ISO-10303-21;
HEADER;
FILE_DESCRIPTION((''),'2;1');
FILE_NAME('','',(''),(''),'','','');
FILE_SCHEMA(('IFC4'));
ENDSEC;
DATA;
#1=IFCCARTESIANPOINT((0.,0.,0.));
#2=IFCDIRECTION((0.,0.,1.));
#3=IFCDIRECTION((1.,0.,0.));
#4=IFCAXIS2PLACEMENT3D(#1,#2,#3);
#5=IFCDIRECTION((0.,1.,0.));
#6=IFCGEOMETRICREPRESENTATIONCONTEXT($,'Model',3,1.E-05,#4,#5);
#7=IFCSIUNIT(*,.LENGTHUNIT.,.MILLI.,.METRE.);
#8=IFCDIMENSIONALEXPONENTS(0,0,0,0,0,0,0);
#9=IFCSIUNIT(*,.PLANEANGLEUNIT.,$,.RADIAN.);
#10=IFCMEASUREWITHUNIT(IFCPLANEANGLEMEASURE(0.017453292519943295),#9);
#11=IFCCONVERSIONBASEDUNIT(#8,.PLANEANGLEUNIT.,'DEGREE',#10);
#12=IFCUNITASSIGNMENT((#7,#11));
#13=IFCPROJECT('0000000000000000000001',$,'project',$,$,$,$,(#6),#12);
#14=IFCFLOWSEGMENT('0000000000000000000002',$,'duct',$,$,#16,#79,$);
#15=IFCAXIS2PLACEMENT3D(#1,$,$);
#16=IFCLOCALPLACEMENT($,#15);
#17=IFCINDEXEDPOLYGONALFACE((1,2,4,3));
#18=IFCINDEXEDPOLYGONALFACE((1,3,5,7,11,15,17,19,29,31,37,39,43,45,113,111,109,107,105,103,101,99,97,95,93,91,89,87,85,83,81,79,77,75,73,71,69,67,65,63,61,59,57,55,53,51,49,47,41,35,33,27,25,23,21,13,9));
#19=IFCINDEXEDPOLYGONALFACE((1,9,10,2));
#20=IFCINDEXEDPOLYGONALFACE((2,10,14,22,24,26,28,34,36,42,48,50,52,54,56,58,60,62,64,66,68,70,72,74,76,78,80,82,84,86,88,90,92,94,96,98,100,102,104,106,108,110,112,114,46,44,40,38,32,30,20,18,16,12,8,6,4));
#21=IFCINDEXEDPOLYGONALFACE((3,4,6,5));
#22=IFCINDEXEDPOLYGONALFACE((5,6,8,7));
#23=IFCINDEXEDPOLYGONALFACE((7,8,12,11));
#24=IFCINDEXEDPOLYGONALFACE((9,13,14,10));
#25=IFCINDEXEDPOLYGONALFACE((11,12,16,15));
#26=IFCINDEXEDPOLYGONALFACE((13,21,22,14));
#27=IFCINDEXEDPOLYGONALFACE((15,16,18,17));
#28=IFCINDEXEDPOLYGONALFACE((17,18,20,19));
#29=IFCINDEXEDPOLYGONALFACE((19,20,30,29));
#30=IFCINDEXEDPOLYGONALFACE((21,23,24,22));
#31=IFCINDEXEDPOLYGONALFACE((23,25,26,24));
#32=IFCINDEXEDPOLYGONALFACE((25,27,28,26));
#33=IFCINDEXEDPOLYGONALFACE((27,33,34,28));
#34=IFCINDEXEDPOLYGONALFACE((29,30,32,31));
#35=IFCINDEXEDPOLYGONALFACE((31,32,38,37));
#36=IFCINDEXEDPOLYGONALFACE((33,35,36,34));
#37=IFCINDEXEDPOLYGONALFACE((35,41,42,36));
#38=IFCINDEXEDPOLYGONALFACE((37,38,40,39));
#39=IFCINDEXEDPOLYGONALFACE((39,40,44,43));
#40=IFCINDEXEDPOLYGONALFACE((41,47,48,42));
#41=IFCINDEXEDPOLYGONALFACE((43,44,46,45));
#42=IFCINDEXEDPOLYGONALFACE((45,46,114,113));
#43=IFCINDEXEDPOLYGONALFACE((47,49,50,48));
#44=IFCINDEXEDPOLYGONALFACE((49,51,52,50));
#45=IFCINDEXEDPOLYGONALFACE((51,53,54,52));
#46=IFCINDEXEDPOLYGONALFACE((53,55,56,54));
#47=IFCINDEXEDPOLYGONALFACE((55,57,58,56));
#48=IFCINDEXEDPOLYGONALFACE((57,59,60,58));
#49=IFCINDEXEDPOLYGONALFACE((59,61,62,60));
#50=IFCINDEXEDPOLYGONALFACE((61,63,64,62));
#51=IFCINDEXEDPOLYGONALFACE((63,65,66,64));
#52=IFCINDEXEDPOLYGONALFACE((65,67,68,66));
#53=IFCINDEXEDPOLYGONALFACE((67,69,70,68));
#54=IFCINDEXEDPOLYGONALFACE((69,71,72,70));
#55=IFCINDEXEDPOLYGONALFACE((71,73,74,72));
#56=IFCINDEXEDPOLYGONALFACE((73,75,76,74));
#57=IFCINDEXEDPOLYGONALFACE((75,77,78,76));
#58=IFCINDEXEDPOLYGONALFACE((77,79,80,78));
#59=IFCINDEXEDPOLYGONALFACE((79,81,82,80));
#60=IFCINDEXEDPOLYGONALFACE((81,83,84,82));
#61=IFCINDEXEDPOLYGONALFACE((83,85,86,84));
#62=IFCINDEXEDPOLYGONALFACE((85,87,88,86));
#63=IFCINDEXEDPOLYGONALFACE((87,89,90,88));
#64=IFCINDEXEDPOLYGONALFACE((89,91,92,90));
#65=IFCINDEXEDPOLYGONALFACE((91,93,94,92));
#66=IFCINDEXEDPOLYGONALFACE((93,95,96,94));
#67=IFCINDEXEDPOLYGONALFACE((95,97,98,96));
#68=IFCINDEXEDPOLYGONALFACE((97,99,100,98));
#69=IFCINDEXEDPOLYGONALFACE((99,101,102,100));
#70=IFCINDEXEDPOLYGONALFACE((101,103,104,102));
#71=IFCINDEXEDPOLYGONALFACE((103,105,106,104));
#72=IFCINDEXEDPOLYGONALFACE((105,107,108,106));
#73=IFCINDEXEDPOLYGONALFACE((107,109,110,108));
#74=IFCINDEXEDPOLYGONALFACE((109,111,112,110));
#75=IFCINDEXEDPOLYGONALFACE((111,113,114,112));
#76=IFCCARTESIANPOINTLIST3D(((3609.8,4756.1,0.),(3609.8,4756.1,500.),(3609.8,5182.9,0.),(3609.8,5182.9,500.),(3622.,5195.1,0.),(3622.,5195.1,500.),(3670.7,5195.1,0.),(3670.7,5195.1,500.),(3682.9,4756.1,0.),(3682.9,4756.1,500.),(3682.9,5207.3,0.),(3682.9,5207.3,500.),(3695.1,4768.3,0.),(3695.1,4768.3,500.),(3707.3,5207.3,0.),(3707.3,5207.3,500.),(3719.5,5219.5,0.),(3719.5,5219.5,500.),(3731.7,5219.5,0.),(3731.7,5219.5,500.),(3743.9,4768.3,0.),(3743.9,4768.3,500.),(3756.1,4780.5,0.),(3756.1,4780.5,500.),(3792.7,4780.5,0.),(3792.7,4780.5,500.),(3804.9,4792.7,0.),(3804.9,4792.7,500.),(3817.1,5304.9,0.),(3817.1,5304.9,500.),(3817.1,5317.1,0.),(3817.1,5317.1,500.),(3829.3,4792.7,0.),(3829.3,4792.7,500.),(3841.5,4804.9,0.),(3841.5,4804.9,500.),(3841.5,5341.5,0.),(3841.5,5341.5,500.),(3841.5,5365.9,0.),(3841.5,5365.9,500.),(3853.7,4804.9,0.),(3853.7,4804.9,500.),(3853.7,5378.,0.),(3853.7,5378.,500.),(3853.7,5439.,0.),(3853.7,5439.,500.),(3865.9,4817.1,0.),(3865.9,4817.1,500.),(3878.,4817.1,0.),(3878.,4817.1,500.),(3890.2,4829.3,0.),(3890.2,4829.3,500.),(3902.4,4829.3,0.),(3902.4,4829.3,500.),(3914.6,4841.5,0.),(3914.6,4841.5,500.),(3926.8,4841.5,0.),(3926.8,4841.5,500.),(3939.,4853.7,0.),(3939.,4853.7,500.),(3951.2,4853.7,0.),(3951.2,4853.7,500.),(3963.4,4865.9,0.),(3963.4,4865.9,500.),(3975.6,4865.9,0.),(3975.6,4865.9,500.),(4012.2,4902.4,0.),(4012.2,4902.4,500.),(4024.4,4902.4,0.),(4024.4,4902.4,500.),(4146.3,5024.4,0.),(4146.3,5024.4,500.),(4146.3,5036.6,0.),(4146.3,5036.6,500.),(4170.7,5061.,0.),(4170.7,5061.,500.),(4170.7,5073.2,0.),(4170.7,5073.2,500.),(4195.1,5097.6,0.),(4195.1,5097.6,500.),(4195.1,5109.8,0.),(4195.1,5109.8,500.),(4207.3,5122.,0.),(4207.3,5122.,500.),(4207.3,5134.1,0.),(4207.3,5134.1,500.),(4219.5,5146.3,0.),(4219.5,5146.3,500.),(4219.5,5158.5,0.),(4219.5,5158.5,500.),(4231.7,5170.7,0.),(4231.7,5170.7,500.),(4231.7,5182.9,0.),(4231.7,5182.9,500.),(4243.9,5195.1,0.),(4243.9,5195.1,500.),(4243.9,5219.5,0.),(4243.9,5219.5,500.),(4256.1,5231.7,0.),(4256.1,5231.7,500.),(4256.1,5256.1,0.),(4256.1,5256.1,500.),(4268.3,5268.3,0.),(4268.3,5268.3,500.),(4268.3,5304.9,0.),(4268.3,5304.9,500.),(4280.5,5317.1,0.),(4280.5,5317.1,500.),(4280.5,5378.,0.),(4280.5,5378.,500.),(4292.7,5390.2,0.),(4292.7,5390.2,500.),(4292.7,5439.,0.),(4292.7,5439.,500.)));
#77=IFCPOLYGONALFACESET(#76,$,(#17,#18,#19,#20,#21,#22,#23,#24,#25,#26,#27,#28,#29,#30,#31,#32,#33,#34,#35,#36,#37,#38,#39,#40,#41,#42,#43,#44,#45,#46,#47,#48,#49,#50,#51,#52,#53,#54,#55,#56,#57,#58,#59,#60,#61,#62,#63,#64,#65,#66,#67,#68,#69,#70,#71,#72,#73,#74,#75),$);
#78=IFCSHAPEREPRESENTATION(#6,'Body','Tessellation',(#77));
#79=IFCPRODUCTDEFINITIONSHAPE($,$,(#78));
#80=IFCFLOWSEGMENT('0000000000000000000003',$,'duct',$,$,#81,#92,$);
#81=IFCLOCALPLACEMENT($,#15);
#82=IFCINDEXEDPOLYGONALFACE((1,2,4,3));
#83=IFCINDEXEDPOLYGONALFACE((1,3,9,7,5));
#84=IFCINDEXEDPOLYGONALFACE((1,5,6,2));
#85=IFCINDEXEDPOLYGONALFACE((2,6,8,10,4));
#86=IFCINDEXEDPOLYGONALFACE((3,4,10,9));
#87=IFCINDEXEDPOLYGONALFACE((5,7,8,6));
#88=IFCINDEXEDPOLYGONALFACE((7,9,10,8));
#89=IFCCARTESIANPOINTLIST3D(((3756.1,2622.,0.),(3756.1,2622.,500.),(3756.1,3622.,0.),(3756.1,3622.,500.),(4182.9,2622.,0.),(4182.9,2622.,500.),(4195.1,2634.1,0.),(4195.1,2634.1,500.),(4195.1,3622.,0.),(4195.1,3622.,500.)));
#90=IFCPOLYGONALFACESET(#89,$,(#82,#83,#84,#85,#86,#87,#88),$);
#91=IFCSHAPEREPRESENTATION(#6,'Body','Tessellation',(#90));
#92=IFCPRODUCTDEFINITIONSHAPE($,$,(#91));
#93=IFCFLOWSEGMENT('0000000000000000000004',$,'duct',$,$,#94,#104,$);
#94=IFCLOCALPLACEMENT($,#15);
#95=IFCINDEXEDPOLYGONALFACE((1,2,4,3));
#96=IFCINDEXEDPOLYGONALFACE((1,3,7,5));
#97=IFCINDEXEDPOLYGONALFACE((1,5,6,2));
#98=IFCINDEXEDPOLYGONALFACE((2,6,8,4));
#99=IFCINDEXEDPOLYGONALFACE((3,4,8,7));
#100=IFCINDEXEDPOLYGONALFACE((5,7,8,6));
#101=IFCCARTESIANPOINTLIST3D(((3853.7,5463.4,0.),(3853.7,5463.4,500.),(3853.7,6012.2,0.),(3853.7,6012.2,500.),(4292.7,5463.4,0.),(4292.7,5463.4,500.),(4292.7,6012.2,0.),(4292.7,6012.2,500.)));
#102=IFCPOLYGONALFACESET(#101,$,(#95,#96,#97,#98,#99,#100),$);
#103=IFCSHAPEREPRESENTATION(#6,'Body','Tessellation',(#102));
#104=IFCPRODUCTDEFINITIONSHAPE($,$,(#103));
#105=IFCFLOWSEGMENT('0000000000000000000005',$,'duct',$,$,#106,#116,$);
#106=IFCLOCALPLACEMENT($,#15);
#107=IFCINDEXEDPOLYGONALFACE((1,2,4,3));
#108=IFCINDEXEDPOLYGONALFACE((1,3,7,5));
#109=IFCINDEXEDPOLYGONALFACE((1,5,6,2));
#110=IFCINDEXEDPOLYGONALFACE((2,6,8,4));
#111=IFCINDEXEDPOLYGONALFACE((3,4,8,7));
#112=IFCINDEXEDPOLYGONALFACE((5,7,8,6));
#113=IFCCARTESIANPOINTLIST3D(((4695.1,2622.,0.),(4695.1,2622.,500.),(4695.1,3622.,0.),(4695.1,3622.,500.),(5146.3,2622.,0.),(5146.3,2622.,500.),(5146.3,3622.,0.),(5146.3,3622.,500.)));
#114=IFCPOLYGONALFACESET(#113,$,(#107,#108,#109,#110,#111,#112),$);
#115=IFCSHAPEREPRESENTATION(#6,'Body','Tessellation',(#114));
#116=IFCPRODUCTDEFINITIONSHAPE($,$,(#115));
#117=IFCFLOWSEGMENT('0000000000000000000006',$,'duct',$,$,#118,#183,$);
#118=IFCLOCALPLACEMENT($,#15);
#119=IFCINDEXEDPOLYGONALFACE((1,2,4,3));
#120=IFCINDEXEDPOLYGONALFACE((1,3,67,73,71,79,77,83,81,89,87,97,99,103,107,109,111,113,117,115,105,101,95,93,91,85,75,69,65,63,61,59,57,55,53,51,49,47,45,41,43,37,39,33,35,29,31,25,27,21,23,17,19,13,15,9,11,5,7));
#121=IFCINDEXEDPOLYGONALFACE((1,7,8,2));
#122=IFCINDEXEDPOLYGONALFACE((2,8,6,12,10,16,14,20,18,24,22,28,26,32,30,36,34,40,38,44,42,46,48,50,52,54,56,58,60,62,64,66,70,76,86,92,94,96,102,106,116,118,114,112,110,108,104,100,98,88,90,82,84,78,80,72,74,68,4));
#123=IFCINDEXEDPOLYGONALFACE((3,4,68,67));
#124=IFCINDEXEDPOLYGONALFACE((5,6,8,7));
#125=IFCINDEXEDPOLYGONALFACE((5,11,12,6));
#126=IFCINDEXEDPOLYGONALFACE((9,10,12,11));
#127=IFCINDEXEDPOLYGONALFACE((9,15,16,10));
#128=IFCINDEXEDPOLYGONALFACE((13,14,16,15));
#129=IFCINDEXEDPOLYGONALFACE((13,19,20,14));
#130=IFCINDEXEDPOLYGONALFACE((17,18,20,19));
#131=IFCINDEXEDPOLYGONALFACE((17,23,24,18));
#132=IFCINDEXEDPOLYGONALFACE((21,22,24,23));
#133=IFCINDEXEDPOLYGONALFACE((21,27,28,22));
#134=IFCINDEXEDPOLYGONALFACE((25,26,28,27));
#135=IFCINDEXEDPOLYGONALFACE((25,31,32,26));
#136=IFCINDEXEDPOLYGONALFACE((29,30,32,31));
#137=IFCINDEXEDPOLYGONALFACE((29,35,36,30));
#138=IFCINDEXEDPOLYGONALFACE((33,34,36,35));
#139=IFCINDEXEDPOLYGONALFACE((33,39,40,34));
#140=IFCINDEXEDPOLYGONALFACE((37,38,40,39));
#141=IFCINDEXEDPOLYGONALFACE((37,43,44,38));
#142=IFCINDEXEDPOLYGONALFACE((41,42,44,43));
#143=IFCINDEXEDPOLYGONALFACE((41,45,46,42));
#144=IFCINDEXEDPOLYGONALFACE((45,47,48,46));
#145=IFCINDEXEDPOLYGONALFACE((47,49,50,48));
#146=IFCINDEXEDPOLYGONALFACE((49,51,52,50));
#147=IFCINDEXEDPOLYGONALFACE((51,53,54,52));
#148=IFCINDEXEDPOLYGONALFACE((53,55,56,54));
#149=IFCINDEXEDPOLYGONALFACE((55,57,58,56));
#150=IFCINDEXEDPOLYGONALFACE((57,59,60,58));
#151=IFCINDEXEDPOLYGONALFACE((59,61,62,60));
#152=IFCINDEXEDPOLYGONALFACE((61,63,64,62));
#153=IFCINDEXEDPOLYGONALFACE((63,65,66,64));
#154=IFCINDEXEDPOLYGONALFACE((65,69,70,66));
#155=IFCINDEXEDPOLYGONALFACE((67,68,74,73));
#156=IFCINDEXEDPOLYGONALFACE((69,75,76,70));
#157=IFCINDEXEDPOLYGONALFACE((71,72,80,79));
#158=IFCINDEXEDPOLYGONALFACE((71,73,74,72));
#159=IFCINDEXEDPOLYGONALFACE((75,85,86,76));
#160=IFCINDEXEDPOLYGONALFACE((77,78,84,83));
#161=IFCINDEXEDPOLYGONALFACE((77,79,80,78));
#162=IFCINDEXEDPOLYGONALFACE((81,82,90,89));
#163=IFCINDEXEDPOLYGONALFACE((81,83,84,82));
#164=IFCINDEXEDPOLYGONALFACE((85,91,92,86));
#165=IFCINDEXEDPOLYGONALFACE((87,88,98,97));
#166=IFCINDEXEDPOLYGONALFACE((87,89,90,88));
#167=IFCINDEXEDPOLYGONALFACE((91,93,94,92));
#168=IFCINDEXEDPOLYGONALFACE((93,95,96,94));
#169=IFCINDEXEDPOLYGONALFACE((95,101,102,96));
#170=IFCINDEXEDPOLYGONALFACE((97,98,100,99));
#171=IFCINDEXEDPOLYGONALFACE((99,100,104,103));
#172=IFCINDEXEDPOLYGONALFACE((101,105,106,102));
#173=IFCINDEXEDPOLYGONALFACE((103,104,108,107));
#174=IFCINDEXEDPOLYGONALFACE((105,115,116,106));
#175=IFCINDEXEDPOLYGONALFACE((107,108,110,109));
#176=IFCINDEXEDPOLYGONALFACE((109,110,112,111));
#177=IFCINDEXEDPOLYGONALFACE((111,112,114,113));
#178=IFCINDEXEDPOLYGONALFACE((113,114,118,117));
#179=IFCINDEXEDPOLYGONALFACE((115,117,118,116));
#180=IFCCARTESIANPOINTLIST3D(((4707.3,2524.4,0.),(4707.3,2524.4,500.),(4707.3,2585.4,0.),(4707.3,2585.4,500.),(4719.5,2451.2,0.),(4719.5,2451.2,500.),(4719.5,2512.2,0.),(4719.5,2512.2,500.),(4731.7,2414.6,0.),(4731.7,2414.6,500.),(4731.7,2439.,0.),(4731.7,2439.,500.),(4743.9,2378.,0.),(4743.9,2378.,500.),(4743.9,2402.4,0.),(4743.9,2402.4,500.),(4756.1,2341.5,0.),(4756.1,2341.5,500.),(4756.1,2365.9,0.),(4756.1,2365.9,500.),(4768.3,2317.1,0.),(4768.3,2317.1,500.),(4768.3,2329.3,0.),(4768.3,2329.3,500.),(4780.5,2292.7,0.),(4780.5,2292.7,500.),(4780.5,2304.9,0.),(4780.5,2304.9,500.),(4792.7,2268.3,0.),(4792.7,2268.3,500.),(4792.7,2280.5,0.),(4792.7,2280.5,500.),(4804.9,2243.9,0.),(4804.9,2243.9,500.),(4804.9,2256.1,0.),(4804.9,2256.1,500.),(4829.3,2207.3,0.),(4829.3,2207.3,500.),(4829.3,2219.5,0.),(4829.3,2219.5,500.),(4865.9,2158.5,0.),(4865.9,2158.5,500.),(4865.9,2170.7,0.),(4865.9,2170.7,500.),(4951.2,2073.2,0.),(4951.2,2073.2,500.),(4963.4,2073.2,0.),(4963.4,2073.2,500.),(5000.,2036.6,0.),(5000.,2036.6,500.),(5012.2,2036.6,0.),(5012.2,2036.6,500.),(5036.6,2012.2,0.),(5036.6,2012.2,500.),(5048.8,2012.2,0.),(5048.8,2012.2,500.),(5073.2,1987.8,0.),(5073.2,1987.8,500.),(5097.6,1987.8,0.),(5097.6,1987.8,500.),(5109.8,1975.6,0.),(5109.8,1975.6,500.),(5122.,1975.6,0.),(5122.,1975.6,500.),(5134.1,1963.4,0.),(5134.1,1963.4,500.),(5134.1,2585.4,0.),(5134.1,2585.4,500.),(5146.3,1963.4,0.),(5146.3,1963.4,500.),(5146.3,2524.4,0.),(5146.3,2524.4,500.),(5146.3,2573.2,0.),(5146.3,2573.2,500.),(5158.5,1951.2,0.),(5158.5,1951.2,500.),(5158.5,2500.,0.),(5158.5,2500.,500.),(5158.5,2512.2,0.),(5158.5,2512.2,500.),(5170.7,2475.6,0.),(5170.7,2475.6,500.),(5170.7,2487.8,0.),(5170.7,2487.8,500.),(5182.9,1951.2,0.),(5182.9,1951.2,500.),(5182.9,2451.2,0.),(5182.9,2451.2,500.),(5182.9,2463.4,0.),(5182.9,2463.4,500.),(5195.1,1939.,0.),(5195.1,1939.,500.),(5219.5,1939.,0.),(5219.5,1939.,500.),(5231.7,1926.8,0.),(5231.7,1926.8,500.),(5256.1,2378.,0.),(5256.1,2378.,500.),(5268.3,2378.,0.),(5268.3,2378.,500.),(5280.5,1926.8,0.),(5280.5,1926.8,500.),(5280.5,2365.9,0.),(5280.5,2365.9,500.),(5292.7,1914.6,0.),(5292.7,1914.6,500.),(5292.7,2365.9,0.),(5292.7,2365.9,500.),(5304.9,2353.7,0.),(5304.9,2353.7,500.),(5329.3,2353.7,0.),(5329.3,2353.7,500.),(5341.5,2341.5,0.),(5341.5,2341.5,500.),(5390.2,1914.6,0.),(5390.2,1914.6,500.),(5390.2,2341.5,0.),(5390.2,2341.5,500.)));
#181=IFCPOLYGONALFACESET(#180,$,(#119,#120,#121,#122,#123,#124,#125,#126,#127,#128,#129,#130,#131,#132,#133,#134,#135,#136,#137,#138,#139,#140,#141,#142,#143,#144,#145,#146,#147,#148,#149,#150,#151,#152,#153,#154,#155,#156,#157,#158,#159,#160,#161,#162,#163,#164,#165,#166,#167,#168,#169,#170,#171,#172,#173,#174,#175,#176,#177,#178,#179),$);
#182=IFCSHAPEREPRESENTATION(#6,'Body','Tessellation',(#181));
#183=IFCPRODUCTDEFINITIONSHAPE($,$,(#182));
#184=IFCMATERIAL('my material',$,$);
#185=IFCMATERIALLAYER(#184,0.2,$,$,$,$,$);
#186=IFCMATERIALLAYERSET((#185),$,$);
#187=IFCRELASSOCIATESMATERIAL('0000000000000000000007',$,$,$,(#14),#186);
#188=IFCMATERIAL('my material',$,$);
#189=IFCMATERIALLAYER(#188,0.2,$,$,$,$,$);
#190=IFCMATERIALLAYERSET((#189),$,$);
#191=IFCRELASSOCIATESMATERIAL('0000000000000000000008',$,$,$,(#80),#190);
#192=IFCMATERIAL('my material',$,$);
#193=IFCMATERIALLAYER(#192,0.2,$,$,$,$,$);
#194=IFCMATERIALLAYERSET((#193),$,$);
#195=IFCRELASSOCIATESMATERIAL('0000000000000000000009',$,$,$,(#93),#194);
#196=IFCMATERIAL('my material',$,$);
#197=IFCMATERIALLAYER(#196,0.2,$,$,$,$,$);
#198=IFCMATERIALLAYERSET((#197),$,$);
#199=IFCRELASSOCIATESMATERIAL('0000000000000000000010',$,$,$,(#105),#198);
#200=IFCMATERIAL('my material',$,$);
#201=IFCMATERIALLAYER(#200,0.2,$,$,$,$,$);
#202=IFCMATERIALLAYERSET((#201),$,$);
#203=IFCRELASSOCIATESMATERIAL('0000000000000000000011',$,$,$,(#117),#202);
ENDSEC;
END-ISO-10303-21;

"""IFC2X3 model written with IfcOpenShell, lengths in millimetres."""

from ifc_helpers import new_model, entity, si_unit, converted_unit, direction, origin_with_axes, place, context, project, polyline, outline, extrude, material, layer, layer_set, layer_usage, element, save


model = new_model("IFC2X3")

# Units and contexts
model_context = context("Model", 3, precision=1e-05, world=origin_with_axes(), true_north=direction((0.0, 1.0, 0.0)))
ifc_project = project(units=[si_unit("LENGTHUNIT", "METRE", prefix="MILLI"), converted_unit("PLANEANGLEUNIT", "DEGREE", entity("IfcPlaneAngleMeasure", 0.017453292519943295), si_unit("PLANEANGLEUNIT", "RADIAN"), dimensions=[0, 0, 0, 0, 0, 0, 0])], contexts=[model_context])

# Flow segments
ifc_material_1 = material(Name="my material")
ifc_layer_1 = layer(ifc_material_1, 0.2)
ifc_layer_set_1 = layer_set([ifc_layer_1])
ifc_layer_usage_1 = layer_usage(ifc_layer_set_1, "AXIS2", "POSITIVE", -0.1)
flow_segment_1_placement = place(None, origin_with_axes())
element("IfcFlowSegment", 1, at=flow_segment_1_placement, material=ifc_layer_usage_1, Name="duct", context=model_context, shape_type="SweptSolid", body=[
    extrude(outline(polyline([(3609.8, 4756.1), (3682.9, 4756.1), (3695.1, 4768.3), (3743.9, 4768.3), (3756.1, 4780.5), (3792.7, 4780.5), (3804.9, 4792.7), (3829.3, 4792.7), (3841.5, 4804.9), (3853.7, 4804.9), (3865.9, 4817.1), (3878.0, 4817.1), (3890.2, 4829.3), (3902.4, 4829.3), (3914.6, 4841.5), (3926.8, 4841.5), (3939.0, 4853.7), (3951.2, 4853.7), (3963.4, 4865.9), (3975.6, 4865.9), (4012.2, 4902.4), (4024.4, 4902.4), (4146.3, 5024.4), (4146.3, 5036.6), (4170.7, 5061.0), (4170.7, 5073.2), (4195.1, 5097.6), (4195.1, 5109.8), (4207.3, 5122.0), (4207.3, 5134.1), (4219.5, 5146.3), (4219.5, 5158.5), (4231.7, 5170.7), (4231.7, 5182.9), (4243.9, 5195.1), (4243.9, 5219.5), (4256.1, 5231.7), (4256.1, 5256.1), (4268.3, 5268.3), (4268.3, 5304.9), (4280.5, 5317.1), (4280.5, 5378.0), (4292.7, 5390.2), (4292.7, 5439.0), (3853.7, 5439.0), (3853.7, 5378.0), (3841.5, 5365.9), (3841.5, 5341.5), (3817.1, 5317.1), (3817.1, 5304.9), (3731.7, 5219.5), (3719.5, 5219.5), (3707.3, 5207.3), (3682.9, 5207.3), (3670.7, 5195.1), (3622.0, 5195.1), (3609.8, 5182.9), (3609.8, 4756.1)])), origin_with_axes(), (0.0, 0.0, 1.0), 500.0),
])
ifc_material_2 = material(Name="my material")
ifc_layer_2 = layer(ifc_material_2, 0.2)
ifc_layer_set_2 = layer_set([ifc_layer_2])
ifc_layer_usage_2 = layer_usage(ifc_layer_set_2, "AXIS2", "POSITIVE", -0.1)
flow_segment_2_placement = place(None, origin_with_axes())
element("IfcFlowSegment", 2, at=flow_segment_2_placement, material=ifc_layer_usage_2, Name="duct", context=model_context, shape_type="SweptSolid", body=[
    extrude(outline(polyline([(3756.1, 2622.0), (4182.9, 2622.0), (4195.1, 2634.1), (4195.1, 3622.0), (3756.1, 3622.0), (3756.1, 2622.0)])), origin_with_axes(), (0.0, 0.0, 1.0), 500.0),
])
ifc_material_3 = material(Name="my material")
ifc_layer_3 = layer(ifc_material_3, 0.2)
ifc_layer_set_3 = layer_set([ifc_layer_3])
ifc_layer_usage_3 = layer_usage(ifc_layer_set_3, "AXIS2", "POSITIVE", -0.1)
flow_segment_3_placement = place(None, origin_with_axes())
element("IfcFlowSegment", 3, at=flow_segment_3_placement, material=ifc_layer_usage_3, Name="duct", context=model_context, shape_type="SweptSolid", body=[
    extrude(outline(polyline([(3853.7, 5463.4), (4292.7, 5463.4), (4292.7, 6012.2), (3853.7, 6012.2), (3853.7, 5463.4)])), origin_with_axes(), (0.0, 0.0, 1.0), 500.0),
])
ifc_material_4 = material(Name="my material")
ifc_layer_4 = layer(ifc_material_4, 0.2)
ifc_layer_set_4 = layer_set([ifc_layer_4])
ifc_layer_usage_4 = layer_usage(ifc_layer_set_4, "AXIS2", "POSITIVE", -0.1)
flow_segment_4_placement = place(None, origin_with_axes())
element("IfcFlowSegment", 4, at=flow_segment_4_placement, material=ifc_layer_usage_4, Name="duct", context=model_context, shape_type="SweptSolid", body=[
    extrude(outline(polyline([(4695.1, 2622.0), (5146.3, 2622.0), (5146.3, 3622.0), (4695.1, 3622.0), (4695.1, 2622.0)])), origin_with_axes(), (0.0, 0.0, 1.0), 500.0),
])
ifc_material_5 = material(Name="my material")
ifc_layer_5 = layer(ifc_material_5, 0.2)
ifc_layer_set_5 = layer_set([ifc_layer_5])
ifc_layer_usage_5 = layer_usage(ifc_layer_set_5, "AXIS2", "POSITIVE", -0.1)
flow_segment_5_placement = place(None, origin_with_axes())
element("IfcFlowSegment", 5, at=flow_segment_5_placement, material=ifc_layer_usage_5, Name="duct", context=model_context, shape_type="SweptSolid", body=[
    extrude(outline(polyline([(4707.3, 2524.4), (4719.5, 2512.2), (4719.5, 2451.2), (4731.7, 2439.0), (4731.7, 2414.6), (4743.9, 2402.4), (4743.9, 2378.0), (4756.1, 2365.9), (4756.1, 2341.5), (4768.3, 2329.3), (4768.3, 2317.1), (4780.5, 2304.9), (4780.5, 2292.7), (4792.7, 2280.5), (4792.7, 2268.3), (4804.9, 2256.1), (4804.9, 2243.9), (4829.3, 2219.5), (4829.3, 2207.3), (4865.9, 2170.7), (4865.9, 2158.5), (4951.2, 2073.2), (4963.4, 2073.2), (5000.0, 2036.6), (5012.2, 2036.6), (5036.6, 2012.2), (5048.8, 2012.2), (5073.2, 1987.8), (5097.6, 1987.8), (5109.8, 1975.6), (5122.0, 1975.6), (5134.1, 1963.4), (5146.3, 1963.4), (5158.5, 1951.2), (5182.9, 1951.2), (5195.1, 1939.0), (5219.5, 1939.0), (5231.7, 1926.8), (5280.5, 1926.8), (5292.7, 1914.6), (5390.2, 1914.6), (5390.2, 2341.5), (5341.5, 2341.5), (5329.3, 2353.7), (5304.9, 2353.7), (5292.7, 2365.9), (5280.5, 2365.9), (5268.3, 2378.0), (5256.1, 2378.0), (5182.9, 2451.2), (5182.9, 2463.4), (5170.7, 2475.6), (5170.7, 2487.8), (5158.5, 2500.0), (5158.5, 2512.2), (5146.3, 2524.4), (5146.3, 2573.2), (5134.1, 2585.4), (4707.3, 2585.4), (4707.3, 2524.4)])), origin_with_axes(), (0.0, 0.0, 1.0), 500.0),
])

save(model, "model.ifc")
